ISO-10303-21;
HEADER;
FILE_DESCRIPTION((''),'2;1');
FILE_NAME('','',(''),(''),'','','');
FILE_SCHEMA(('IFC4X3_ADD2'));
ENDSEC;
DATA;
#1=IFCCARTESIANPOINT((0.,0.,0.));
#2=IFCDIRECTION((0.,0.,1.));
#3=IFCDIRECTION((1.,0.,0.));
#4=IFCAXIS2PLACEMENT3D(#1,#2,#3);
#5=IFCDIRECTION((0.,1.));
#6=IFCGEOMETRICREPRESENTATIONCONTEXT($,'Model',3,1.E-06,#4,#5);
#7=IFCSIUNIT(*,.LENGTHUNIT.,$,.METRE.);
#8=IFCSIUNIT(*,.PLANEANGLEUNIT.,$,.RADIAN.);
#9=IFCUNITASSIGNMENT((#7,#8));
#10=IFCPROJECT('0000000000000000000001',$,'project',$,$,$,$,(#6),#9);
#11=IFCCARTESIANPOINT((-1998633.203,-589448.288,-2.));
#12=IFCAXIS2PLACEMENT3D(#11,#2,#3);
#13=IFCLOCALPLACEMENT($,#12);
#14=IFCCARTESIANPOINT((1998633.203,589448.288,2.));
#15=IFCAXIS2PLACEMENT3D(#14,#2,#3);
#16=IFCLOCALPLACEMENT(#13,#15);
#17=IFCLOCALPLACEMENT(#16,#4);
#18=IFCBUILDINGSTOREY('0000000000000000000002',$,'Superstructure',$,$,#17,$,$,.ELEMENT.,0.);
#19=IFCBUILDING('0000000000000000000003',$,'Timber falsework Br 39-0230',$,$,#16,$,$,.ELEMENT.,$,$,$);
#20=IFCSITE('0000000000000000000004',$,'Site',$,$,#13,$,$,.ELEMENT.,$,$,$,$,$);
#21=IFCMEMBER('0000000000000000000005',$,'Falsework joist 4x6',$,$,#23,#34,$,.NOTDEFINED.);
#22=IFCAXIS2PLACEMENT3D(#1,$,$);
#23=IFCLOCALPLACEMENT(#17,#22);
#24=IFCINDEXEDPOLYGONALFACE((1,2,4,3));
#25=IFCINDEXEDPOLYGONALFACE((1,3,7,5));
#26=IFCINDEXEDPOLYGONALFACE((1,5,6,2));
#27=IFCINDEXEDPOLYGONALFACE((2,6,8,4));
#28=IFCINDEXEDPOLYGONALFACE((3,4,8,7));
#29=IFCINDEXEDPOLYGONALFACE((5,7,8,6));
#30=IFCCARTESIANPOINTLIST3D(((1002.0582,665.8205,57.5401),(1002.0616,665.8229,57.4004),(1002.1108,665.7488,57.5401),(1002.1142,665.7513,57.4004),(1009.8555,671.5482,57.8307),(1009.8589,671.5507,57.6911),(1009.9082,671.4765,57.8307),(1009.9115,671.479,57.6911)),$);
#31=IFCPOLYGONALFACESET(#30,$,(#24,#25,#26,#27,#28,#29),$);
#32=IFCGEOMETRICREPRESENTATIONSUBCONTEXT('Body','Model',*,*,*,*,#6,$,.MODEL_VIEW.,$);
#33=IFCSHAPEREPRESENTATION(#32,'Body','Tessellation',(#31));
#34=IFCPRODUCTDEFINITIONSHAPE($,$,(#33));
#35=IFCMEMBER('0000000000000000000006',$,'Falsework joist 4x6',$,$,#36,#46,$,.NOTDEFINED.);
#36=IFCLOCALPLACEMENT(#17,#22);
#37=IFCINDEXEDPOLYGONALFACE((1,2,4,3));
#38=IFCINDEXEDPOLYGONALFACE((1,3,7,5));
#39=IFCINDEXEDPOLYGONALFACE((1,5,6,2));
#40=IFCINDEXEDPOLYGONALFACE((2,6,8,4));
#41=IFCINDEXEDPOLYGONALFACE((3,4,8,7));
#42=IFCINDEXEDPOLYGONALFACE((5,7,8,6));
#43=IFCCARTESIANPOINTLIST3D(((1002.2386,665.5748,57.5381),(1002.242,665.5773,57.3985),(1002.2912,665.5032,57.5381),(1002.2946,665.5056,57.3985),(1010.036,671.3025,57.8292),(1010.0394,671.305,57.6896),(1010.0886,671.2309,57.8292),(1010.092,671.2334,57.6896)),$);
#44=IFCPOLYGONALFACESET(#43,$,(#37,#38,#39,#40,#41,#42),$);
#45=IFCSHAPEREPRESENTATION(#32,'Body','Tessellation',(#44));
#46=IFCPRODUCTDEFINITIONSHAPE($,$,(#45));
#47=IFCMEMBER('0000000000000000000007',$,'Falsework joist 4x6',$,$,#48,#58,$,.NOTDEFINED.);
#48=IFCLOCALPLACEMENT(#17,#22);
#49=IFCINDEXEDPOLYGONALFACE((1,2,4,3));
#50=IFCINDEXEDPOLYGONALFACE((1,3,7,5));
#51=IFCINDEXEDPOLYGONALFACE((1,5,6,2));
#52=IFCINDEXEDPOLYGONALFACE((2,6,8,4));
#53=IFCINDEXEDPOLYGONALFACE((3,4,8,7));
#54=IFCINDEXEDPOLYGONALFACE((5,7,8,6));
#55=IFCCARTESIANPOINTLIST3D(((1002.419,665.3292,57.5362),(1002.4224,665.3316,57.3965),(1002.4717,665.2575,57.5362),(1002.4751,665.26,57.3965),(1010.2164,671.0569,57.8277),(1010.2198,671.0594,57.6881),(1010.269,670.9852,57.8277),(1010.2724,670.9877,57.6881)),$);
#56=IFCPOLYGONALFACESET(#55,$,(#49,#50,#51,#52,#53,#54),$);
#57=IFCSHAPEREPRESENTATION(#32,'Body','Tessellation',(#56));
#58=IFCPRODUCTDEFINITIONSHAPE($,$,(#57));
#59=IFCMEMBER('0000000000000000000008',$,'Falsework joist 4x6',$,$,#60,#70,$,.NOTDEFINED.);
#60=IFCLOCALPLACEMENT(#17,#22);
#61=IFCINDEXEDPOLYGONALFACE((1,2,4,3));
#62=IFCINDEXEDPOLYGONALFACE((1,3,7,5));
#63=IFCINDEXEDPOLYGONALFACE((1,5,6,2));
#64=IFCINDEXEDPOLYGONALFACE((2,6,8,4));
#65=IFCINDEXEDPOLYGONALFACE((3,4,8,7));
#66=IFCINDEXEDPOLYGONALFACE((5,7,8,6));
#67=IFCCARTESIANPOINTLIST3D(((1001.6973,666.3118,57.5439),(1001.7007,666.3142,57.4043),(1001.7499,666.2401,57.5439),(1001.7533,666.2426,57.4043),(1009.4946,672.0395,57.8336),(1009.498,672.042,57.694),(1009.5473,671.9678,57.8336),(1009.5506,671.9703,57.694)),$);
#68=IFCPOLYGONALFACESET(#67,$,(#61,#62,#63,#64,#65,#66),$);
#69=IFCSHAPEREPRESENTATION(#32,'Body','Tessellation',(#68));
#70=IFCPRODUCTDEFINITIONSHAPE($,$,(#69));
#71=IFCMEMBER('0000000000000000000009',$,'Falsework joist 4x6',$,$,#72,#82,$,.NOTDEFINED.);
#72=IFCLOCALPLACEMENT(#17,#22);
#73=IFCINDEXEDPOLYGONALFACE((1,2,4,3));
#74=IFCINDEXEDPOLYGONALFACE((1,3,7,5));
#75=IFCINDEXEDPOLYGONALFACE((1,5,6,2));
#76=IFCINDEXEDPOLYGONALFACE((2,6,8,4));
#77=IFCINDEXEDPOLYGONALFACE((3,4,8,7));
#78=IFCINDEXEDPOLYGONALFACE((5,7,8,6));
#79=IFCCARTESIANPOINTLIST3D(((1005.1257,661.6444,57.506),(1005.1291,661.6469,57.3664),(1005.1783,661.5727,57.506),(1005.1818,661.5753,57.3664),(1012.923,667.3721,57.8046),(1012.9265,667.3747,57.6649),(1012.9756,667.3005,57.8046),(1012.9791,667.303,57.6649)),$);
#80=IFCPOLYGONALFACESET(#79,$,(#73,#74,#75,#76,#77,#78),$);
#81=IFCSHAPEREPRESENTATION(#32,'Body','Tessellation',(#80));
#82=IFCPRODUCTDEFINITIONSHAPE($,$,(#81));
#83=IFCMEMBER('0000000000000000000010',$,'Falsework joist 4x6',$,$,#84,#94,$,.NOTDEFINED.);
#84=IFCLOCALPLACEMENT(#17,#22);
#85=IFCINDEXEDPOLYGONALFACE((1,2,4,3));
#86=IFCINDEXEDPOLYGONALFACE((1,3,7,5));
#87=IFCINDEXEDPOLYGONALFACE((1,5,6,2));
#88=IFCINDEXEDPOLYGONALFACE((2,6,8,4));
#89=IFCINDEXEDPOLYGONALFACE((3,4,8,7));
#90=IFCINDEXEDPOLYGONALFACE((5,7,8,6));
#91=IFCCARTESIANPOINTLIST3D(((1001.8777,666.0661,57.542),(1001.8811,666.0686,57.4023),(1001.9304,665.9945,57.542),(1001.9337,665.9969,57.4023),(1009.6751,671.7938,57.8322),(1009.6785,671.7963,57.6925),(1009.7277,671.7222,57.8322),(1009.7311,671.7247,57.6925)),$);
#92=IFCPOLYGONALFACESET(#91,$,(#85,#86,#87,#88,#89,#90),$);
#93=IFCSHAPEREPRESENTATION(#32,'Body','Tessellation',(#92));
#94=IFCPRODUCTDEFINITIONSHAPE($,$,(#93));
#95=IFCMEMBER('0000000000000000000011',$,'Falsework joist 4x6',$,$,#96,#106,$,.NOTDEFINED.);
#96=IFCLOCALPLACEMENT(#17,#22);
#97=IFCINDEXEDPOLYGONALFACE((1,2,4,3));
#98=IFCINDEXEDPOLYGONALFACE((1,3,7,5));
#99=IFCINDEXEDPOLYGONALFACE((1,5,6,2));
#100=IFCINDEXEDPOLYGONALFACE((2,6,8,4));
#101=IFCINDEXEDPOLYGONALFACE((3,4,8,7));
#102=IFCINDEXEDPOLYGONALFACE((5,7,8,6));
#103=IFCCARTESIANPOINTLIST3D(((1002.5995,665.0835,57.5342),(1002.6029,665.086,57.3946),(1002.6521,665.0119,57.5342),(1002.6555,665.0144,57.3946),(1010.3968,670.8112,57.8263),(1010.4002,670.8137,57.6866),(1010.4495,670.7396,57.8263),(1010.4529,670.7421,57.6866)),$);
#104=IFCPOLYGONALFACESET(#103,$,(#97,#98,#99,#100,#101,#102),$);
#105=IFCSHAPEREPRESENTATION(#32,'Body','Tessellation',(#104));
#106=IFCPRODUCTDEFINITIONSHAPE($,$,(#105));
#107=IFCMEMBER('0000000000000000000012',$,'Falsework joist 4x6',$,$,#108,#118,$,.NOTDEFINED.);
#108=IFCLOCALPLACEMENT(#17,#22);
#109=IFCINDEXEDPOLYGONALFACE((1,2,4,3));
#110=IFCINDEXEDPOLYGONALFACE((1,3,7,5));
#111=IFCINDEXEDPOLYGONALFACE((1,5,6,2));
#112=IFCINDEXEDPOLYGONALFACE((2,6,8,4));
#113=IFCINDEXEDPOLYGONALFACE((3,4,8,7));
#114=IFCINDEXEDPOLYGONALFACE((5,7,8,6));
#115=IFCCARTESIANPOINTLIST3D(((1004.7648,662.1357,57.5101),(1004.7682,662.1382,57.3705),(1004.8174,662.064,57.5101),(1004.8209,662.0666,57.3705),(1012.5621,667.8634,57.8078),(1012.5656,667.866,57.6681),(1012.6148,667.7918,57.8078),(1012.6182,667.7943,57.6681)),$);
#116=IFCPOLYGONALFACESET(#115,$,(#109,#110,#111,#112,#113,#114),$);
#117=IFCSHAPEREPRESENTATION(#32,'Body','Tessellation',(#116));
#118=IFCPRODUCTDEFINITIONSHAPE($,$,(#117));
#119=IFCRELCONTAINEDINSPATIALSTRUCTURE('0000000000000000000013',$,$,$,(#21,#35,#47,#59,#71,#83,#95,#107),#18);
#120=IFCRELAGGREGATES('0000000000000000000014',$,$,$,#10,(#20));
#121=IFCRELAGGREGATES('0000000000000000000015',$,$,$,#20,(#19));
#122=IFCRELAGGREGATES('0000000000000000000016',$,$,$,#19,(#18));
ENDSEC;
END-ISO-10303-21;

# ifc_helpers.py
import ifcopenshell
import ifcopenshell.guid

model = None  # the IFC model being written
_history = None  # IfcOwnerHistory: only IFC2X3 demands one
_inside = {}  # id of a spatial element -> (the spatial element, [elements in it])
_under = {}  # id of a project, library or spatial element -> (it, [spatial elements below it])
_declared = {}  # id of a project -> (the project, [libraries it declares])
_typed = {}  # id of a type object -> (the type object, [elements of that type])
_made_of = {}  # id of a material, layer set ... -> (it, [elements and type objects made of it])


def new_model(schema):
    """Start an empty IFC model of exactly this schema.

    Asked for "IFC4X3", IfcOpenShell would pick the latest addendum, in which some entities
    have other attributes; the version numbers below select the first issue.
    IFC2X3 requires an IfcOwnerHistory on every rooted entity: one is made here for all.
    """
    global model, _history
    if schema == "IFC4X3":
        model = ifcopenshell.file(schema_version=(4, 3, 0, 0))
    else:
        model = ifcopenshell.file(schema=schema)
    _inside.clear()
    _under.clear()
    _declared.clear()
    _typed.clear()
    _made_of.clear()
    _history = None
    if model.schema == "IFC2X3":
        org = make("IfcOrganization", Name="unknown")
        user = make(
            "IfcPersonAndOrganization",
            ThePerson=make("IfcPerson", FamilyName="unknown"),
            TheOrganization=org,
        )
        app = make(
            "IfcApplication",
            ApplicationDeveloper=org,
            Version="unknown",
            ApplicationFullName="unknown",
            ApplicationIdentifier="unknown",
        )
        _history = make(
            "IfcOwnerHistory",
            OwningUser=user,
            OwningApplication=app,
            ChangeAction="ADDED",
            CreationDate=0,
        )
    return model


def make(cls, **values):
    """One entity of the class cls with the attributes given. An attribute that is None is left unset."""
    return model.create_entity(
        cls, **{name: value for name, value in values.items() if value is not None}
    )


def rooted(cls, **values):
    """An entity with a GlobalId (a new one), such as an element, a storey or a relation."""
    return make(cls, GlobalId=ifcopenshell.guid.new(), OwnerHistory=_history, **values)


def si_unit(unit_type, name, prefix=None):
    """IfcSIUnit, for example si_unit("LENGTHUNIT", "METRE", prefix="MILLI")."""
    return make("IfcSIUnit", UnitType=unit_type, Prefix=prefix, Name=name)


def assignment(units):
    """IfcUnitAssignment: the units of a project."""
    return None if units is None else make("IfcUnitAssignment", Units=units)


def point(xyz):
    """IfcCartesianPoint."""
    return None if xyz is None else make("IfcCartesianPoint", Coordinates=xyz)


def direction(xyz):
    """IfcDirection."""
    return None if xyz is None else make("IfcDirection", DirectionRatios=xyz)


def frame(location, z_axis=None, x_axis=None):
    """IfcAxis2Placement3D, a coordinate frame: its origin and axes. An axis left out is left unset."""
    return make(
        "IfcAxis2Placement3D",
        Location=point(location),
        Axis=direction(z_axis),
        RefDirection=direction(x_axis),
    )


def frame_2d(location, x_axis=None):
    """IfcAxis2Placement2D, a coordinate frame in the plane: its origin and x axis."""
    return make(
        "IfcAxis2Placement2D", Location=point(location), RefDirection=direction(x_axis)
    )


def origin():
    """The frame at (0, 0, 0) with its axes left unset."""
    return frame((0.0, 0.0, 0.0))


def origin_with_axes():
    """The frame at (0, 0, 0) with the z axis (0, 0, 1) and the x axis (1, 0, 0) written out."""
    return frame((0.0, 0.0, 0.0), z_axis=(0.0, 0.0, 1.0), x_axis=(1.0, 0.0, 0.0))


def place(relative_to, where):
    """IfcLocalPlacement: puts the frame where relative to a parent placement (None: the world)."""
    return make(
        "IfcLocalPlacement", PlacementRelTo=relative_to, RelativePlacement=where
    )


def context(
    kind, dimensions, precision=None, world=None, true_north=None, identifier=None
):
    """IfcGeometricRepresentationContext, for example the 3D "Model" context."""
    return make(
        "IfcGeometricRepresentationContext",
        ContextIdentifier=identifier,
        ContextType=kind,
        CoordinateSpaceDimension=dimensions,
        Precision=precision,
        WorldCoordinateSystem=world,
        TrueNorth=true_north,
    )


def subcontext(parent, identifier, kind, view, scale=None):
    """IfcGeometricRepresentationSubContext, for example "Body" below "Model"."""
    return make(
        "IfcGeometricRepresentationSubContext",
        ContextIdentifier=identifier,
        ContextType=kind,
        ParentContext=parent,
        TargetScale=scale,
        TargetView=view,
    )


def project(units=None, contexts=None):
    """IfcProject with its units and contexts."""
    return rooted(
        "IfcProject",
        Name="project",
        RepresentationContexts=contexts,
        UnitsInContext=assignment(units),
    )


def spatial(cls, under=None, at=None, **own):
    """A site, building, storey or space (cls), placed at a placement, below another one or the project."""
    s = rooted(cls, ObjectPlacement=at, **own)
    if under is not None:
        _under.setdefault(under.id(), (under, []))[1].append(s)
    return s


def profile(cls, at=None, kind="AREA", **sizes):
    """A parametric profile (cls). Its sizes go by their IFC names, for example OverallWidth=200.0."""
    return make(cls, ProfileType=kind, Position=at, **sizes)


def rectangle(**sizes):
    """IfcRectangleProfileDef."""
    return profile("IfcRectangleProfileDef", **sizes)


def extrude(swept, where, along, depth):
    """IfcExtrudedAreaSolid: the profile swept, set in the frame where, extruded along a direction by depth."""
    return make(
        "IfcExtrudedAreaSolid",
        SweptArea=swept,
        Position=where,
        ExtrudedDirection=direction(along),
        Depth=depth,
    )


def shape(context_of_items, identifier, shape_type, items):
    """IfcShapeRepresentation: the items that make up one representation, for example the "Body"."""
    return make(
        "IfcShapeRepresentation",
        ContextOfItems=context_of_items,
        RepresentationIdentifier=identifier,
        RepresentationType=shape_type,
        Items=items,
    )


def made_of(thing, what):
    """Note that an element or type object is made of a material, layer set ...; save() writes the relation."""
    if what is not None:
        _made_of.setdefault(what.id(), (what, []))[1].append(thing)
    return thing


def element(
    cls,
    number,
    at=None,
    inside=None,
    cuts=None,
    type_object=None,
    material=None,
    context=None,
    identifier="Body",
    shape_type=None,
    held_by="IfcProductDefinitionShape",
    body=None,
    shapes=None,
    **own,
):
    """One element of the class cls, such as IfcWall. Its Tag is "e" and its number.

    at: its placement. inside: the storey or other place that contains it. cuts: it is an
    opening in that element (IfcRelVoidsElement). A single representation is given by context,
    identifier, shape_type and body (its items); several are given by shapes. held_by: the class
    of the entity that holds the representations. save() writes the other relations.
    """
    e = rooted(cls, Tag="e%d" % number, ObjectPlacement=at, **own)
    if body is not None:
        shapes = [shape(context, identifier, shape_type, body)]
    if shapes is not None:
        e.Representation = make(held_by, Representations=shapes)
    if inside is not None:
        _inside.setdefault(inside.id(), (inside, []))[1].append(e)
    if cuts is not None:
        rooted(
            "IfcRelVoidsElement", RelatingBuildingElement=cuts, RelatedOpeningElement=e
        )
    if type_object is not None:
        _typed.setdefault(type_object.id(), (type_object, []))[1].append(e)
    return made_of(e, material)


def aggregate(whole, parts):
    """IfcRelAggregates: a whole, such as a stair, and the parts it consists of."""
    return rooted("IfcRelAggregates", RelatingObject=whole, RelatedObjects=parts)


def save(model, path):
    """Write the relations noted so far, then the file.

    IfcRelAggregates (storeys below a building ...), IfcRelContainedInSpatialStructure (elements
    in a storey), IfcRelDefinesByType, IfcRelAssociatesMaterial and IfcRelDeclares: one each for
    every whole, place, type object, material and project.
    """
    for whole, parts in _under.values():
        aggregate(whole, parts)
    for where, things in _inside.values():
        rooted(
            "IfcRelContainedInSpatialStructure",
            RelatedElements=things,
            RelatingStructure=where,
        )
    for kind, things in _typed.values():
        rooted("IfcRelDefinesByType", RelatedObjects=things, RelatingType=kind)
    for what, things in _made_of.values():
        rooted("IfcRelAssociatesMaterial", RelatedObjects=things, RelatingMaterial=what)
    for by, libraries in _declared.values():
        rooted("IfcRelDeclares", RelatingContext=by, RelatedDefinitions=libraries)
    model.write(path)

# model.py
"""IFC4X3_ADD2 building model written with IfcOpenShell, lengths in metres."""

from ifc_helpers import new_model, si_unit, direction, frame, frame_2d, origin, origin_with_axes, place, context, subcontext, project, spatial, rectangle, extrude, element, save


model = new_model("IFC4X3_ADD2")

# Units and contexts
model_context = context("Model", 3, precision=1e-06, world=origin_with_axes(), true_north=direction((0.0, 1.0)))
body_context = subcontext(model_context, "Body", "Model", "MODEL_VIEW")
ifc_project = project(units=[si_unit("LENGTHUNIT", "METRE"), si_unit("PLANEANGLEUNIT", "RADIAN")], contexts=[model_context])

# Site, building, storey
site_placement = place(None, frame((-1998633.203, -589448.288, -2.0), z_axis=(0.0, 0.0, 1.0), x_axis=(1.0, 0.0, 0.0)))
site = spatial("IfcSite", under=ifc_project, at=site_placement, Name="Site", CompositionType="ELEMENT")
building_placement = place(site_placement, frame((1998633.203, 589448.288, 2.0), z_axis=(0.0, 0.0, 1.0), x_axis=(1.0, 0.0, 0.0)))
building = spatial("IfcBuilding", under=site, at=building_placement, Name="Timber falsework Br 39-0230", CompositionType="ELEMENT")
storey_placement = place(building_placement, origin_with_axes())
storey = spatial("IfcBuildingStorey", under=building, at=storey_placement, Name="Superstructure", CompositionType="ELEMENT", Elevation=0.0)

# Members
member_1_placement = place(storey_placement, frame((1002.0879, 665.7871, 57.4004), z_axis=(0.805565, 0.591746, 0.030028), x_axis=(-0.592013, 0.805928, 0.0)))
element("IfcMember", 1, at=member_1_placement, inside=storey, Name="Falsework joist 4x6", PredefinedType="NOTDEFINED", context=body_context, shape_type="SweptSolid", body=[
    extrude(rectangle(XDim=0.0889, YDim=0.1397, at=frame_2d((0.0, 0.0698))), origin(), (0.0, 0.0, 1.0), 9.6794),
])
member_2_placement = place(storey_placement, frame((1002.2683, 665.5415, 57.3985), z_axis=(0.805564, 0.591745, 0.030076), x_axis=(-0.592013, 0.805928, 0.0)))
element("IfcMember", 2, at=member_2_placement, inside=storey, Name="Falsework joist 4x6", PredefinedType="NOTDEFINED", context=body_context, shape_type="SweptSolid", body=[
    extrude(rectangle(XDim=0.0889, YDim=0.1397, at=frame_2d((0.0, 0.0698))), origin(), (0.0, 0.0, 1.0), 9.6794),
])
member_3_placement = place(storey_placement, frame((1002.4488, 665.2958, 57.3965), z_axis=(0.805563, 0.591745, 0.030124), x_axis=(-0.592013, 0.805928, 0.0)))
element("IfcMember", 3, at=member_3_placement, inside=storey, Name="Falsework joist 4x6", PredefinedType="NOTDEFINED", context=body_context, shape_type="SweptSolid", body=[
    extrude(rectangle(XDim=0.0889, YDim=0.1397, at=frame_2d((0.0, 0.0698))), origin(), (0.0, 0.0, 1.0), 9.6794),
])
member_4_placement = place(storey_placement, frame((1001.727, 666.2784, 57.4043), z_axis=(0.805567, 0.591748, 0.029931), x_axis=(-0.592013, 0.805928, 0.0)))
element("IfcMember", 4, at=member_4_placement, inside=storey, Name="Falsework joist 4x6", PredefinedType="NOTDEFINED", context=body_context, shape_type="SweptSolid", body=[
    extrude(rectangle(XDim=0.0889, YDim=0.1397, at=frame_2d((0.0, 0.0698))), origin(), (0.0, 0.0, 1.0), 9.6793),
])
member_5_placement = place(storey_placement, frame((1005.1554, 661.6111, 57.3664), z_axis=(0.805545, 0.591731, 0.030844), x_axis=(-0.592013, 0.805928, 0.0)))
element("IfcMember", 5, at=member_5_placement, inside=storey, Name="Falsework joist 4x6", PredefinedType="NOTDEFINED", context=body_context, shape_type="SweptSolid", body=[
    extrude(rectangle(XDim=0.0889, YDim=0.1397, at=frame_2d((0.0, 0.0698))), origin(), (0.0, 0.0, 1.0), 9.6796),
])
member_6_placement = place(storey_placement, frame((1001.9074, 666.0328, 57.4023), z_axis=(0.805566, 0.591747, 0.02998), x_axis=(-0.592013, 0.805928, 0.0)))
element("IfcMember", 6, at=member_6_placement, inside=storey, Name="Falsework joist 4x6", PredefinedType="NOTDEFINED", context=body_context, shape_type="SweptSolid", body=[
    extrude(rectangle(XDim=0.0889, YDim=0.1397, at=frame_2d((0.0, 0.0698))), origin(), (0.0, 0.0, 1.0), 9.6794),
])
member_7_placement = place(storey_placement, frame((1002.6292, 665.0502, 57.3946), z_axis=(0.805561, 0.591744, 0.030172), x_axis=(-0.592013, 0.805928, 0.0)))
element("IfcMember", 7, at=member_7_placement, inside=storey, Name="Falsework joist 4x6", PredefinedType="NOTDEFINED", context=body_context, shape_type="SweptSolid", body=[
    extrude(rectangle(XDim=0.0889, YDim=0.1397, at=frame_2d((0.0, 0.0698))), origin(), (0.0, 0.0, 1.0), 9.6794),
])
member_8_placement = place(storey_placement, frame((1004.7945, 662.1024, 57.3705), z_axis=(0.805547, 0.591733, 0.030748), x_axis=(-0.592013, 0.805928, 0.0)))
element("IfcMember", 8, at=member_8_placement, inside=storey, Name="Falsework joist 4x6", PredefinedType="NOTDEFINED", context=body_context, shape_type="SweptSolid", body=[
    extrude(rectangle(XDim=0.0889, YDim=0.1397, at=frame_2d((0.0, 0.0698))), origin(), (0.0, 0.0, 1.0), 9.6796),
])

save(model, "model.ifc")
